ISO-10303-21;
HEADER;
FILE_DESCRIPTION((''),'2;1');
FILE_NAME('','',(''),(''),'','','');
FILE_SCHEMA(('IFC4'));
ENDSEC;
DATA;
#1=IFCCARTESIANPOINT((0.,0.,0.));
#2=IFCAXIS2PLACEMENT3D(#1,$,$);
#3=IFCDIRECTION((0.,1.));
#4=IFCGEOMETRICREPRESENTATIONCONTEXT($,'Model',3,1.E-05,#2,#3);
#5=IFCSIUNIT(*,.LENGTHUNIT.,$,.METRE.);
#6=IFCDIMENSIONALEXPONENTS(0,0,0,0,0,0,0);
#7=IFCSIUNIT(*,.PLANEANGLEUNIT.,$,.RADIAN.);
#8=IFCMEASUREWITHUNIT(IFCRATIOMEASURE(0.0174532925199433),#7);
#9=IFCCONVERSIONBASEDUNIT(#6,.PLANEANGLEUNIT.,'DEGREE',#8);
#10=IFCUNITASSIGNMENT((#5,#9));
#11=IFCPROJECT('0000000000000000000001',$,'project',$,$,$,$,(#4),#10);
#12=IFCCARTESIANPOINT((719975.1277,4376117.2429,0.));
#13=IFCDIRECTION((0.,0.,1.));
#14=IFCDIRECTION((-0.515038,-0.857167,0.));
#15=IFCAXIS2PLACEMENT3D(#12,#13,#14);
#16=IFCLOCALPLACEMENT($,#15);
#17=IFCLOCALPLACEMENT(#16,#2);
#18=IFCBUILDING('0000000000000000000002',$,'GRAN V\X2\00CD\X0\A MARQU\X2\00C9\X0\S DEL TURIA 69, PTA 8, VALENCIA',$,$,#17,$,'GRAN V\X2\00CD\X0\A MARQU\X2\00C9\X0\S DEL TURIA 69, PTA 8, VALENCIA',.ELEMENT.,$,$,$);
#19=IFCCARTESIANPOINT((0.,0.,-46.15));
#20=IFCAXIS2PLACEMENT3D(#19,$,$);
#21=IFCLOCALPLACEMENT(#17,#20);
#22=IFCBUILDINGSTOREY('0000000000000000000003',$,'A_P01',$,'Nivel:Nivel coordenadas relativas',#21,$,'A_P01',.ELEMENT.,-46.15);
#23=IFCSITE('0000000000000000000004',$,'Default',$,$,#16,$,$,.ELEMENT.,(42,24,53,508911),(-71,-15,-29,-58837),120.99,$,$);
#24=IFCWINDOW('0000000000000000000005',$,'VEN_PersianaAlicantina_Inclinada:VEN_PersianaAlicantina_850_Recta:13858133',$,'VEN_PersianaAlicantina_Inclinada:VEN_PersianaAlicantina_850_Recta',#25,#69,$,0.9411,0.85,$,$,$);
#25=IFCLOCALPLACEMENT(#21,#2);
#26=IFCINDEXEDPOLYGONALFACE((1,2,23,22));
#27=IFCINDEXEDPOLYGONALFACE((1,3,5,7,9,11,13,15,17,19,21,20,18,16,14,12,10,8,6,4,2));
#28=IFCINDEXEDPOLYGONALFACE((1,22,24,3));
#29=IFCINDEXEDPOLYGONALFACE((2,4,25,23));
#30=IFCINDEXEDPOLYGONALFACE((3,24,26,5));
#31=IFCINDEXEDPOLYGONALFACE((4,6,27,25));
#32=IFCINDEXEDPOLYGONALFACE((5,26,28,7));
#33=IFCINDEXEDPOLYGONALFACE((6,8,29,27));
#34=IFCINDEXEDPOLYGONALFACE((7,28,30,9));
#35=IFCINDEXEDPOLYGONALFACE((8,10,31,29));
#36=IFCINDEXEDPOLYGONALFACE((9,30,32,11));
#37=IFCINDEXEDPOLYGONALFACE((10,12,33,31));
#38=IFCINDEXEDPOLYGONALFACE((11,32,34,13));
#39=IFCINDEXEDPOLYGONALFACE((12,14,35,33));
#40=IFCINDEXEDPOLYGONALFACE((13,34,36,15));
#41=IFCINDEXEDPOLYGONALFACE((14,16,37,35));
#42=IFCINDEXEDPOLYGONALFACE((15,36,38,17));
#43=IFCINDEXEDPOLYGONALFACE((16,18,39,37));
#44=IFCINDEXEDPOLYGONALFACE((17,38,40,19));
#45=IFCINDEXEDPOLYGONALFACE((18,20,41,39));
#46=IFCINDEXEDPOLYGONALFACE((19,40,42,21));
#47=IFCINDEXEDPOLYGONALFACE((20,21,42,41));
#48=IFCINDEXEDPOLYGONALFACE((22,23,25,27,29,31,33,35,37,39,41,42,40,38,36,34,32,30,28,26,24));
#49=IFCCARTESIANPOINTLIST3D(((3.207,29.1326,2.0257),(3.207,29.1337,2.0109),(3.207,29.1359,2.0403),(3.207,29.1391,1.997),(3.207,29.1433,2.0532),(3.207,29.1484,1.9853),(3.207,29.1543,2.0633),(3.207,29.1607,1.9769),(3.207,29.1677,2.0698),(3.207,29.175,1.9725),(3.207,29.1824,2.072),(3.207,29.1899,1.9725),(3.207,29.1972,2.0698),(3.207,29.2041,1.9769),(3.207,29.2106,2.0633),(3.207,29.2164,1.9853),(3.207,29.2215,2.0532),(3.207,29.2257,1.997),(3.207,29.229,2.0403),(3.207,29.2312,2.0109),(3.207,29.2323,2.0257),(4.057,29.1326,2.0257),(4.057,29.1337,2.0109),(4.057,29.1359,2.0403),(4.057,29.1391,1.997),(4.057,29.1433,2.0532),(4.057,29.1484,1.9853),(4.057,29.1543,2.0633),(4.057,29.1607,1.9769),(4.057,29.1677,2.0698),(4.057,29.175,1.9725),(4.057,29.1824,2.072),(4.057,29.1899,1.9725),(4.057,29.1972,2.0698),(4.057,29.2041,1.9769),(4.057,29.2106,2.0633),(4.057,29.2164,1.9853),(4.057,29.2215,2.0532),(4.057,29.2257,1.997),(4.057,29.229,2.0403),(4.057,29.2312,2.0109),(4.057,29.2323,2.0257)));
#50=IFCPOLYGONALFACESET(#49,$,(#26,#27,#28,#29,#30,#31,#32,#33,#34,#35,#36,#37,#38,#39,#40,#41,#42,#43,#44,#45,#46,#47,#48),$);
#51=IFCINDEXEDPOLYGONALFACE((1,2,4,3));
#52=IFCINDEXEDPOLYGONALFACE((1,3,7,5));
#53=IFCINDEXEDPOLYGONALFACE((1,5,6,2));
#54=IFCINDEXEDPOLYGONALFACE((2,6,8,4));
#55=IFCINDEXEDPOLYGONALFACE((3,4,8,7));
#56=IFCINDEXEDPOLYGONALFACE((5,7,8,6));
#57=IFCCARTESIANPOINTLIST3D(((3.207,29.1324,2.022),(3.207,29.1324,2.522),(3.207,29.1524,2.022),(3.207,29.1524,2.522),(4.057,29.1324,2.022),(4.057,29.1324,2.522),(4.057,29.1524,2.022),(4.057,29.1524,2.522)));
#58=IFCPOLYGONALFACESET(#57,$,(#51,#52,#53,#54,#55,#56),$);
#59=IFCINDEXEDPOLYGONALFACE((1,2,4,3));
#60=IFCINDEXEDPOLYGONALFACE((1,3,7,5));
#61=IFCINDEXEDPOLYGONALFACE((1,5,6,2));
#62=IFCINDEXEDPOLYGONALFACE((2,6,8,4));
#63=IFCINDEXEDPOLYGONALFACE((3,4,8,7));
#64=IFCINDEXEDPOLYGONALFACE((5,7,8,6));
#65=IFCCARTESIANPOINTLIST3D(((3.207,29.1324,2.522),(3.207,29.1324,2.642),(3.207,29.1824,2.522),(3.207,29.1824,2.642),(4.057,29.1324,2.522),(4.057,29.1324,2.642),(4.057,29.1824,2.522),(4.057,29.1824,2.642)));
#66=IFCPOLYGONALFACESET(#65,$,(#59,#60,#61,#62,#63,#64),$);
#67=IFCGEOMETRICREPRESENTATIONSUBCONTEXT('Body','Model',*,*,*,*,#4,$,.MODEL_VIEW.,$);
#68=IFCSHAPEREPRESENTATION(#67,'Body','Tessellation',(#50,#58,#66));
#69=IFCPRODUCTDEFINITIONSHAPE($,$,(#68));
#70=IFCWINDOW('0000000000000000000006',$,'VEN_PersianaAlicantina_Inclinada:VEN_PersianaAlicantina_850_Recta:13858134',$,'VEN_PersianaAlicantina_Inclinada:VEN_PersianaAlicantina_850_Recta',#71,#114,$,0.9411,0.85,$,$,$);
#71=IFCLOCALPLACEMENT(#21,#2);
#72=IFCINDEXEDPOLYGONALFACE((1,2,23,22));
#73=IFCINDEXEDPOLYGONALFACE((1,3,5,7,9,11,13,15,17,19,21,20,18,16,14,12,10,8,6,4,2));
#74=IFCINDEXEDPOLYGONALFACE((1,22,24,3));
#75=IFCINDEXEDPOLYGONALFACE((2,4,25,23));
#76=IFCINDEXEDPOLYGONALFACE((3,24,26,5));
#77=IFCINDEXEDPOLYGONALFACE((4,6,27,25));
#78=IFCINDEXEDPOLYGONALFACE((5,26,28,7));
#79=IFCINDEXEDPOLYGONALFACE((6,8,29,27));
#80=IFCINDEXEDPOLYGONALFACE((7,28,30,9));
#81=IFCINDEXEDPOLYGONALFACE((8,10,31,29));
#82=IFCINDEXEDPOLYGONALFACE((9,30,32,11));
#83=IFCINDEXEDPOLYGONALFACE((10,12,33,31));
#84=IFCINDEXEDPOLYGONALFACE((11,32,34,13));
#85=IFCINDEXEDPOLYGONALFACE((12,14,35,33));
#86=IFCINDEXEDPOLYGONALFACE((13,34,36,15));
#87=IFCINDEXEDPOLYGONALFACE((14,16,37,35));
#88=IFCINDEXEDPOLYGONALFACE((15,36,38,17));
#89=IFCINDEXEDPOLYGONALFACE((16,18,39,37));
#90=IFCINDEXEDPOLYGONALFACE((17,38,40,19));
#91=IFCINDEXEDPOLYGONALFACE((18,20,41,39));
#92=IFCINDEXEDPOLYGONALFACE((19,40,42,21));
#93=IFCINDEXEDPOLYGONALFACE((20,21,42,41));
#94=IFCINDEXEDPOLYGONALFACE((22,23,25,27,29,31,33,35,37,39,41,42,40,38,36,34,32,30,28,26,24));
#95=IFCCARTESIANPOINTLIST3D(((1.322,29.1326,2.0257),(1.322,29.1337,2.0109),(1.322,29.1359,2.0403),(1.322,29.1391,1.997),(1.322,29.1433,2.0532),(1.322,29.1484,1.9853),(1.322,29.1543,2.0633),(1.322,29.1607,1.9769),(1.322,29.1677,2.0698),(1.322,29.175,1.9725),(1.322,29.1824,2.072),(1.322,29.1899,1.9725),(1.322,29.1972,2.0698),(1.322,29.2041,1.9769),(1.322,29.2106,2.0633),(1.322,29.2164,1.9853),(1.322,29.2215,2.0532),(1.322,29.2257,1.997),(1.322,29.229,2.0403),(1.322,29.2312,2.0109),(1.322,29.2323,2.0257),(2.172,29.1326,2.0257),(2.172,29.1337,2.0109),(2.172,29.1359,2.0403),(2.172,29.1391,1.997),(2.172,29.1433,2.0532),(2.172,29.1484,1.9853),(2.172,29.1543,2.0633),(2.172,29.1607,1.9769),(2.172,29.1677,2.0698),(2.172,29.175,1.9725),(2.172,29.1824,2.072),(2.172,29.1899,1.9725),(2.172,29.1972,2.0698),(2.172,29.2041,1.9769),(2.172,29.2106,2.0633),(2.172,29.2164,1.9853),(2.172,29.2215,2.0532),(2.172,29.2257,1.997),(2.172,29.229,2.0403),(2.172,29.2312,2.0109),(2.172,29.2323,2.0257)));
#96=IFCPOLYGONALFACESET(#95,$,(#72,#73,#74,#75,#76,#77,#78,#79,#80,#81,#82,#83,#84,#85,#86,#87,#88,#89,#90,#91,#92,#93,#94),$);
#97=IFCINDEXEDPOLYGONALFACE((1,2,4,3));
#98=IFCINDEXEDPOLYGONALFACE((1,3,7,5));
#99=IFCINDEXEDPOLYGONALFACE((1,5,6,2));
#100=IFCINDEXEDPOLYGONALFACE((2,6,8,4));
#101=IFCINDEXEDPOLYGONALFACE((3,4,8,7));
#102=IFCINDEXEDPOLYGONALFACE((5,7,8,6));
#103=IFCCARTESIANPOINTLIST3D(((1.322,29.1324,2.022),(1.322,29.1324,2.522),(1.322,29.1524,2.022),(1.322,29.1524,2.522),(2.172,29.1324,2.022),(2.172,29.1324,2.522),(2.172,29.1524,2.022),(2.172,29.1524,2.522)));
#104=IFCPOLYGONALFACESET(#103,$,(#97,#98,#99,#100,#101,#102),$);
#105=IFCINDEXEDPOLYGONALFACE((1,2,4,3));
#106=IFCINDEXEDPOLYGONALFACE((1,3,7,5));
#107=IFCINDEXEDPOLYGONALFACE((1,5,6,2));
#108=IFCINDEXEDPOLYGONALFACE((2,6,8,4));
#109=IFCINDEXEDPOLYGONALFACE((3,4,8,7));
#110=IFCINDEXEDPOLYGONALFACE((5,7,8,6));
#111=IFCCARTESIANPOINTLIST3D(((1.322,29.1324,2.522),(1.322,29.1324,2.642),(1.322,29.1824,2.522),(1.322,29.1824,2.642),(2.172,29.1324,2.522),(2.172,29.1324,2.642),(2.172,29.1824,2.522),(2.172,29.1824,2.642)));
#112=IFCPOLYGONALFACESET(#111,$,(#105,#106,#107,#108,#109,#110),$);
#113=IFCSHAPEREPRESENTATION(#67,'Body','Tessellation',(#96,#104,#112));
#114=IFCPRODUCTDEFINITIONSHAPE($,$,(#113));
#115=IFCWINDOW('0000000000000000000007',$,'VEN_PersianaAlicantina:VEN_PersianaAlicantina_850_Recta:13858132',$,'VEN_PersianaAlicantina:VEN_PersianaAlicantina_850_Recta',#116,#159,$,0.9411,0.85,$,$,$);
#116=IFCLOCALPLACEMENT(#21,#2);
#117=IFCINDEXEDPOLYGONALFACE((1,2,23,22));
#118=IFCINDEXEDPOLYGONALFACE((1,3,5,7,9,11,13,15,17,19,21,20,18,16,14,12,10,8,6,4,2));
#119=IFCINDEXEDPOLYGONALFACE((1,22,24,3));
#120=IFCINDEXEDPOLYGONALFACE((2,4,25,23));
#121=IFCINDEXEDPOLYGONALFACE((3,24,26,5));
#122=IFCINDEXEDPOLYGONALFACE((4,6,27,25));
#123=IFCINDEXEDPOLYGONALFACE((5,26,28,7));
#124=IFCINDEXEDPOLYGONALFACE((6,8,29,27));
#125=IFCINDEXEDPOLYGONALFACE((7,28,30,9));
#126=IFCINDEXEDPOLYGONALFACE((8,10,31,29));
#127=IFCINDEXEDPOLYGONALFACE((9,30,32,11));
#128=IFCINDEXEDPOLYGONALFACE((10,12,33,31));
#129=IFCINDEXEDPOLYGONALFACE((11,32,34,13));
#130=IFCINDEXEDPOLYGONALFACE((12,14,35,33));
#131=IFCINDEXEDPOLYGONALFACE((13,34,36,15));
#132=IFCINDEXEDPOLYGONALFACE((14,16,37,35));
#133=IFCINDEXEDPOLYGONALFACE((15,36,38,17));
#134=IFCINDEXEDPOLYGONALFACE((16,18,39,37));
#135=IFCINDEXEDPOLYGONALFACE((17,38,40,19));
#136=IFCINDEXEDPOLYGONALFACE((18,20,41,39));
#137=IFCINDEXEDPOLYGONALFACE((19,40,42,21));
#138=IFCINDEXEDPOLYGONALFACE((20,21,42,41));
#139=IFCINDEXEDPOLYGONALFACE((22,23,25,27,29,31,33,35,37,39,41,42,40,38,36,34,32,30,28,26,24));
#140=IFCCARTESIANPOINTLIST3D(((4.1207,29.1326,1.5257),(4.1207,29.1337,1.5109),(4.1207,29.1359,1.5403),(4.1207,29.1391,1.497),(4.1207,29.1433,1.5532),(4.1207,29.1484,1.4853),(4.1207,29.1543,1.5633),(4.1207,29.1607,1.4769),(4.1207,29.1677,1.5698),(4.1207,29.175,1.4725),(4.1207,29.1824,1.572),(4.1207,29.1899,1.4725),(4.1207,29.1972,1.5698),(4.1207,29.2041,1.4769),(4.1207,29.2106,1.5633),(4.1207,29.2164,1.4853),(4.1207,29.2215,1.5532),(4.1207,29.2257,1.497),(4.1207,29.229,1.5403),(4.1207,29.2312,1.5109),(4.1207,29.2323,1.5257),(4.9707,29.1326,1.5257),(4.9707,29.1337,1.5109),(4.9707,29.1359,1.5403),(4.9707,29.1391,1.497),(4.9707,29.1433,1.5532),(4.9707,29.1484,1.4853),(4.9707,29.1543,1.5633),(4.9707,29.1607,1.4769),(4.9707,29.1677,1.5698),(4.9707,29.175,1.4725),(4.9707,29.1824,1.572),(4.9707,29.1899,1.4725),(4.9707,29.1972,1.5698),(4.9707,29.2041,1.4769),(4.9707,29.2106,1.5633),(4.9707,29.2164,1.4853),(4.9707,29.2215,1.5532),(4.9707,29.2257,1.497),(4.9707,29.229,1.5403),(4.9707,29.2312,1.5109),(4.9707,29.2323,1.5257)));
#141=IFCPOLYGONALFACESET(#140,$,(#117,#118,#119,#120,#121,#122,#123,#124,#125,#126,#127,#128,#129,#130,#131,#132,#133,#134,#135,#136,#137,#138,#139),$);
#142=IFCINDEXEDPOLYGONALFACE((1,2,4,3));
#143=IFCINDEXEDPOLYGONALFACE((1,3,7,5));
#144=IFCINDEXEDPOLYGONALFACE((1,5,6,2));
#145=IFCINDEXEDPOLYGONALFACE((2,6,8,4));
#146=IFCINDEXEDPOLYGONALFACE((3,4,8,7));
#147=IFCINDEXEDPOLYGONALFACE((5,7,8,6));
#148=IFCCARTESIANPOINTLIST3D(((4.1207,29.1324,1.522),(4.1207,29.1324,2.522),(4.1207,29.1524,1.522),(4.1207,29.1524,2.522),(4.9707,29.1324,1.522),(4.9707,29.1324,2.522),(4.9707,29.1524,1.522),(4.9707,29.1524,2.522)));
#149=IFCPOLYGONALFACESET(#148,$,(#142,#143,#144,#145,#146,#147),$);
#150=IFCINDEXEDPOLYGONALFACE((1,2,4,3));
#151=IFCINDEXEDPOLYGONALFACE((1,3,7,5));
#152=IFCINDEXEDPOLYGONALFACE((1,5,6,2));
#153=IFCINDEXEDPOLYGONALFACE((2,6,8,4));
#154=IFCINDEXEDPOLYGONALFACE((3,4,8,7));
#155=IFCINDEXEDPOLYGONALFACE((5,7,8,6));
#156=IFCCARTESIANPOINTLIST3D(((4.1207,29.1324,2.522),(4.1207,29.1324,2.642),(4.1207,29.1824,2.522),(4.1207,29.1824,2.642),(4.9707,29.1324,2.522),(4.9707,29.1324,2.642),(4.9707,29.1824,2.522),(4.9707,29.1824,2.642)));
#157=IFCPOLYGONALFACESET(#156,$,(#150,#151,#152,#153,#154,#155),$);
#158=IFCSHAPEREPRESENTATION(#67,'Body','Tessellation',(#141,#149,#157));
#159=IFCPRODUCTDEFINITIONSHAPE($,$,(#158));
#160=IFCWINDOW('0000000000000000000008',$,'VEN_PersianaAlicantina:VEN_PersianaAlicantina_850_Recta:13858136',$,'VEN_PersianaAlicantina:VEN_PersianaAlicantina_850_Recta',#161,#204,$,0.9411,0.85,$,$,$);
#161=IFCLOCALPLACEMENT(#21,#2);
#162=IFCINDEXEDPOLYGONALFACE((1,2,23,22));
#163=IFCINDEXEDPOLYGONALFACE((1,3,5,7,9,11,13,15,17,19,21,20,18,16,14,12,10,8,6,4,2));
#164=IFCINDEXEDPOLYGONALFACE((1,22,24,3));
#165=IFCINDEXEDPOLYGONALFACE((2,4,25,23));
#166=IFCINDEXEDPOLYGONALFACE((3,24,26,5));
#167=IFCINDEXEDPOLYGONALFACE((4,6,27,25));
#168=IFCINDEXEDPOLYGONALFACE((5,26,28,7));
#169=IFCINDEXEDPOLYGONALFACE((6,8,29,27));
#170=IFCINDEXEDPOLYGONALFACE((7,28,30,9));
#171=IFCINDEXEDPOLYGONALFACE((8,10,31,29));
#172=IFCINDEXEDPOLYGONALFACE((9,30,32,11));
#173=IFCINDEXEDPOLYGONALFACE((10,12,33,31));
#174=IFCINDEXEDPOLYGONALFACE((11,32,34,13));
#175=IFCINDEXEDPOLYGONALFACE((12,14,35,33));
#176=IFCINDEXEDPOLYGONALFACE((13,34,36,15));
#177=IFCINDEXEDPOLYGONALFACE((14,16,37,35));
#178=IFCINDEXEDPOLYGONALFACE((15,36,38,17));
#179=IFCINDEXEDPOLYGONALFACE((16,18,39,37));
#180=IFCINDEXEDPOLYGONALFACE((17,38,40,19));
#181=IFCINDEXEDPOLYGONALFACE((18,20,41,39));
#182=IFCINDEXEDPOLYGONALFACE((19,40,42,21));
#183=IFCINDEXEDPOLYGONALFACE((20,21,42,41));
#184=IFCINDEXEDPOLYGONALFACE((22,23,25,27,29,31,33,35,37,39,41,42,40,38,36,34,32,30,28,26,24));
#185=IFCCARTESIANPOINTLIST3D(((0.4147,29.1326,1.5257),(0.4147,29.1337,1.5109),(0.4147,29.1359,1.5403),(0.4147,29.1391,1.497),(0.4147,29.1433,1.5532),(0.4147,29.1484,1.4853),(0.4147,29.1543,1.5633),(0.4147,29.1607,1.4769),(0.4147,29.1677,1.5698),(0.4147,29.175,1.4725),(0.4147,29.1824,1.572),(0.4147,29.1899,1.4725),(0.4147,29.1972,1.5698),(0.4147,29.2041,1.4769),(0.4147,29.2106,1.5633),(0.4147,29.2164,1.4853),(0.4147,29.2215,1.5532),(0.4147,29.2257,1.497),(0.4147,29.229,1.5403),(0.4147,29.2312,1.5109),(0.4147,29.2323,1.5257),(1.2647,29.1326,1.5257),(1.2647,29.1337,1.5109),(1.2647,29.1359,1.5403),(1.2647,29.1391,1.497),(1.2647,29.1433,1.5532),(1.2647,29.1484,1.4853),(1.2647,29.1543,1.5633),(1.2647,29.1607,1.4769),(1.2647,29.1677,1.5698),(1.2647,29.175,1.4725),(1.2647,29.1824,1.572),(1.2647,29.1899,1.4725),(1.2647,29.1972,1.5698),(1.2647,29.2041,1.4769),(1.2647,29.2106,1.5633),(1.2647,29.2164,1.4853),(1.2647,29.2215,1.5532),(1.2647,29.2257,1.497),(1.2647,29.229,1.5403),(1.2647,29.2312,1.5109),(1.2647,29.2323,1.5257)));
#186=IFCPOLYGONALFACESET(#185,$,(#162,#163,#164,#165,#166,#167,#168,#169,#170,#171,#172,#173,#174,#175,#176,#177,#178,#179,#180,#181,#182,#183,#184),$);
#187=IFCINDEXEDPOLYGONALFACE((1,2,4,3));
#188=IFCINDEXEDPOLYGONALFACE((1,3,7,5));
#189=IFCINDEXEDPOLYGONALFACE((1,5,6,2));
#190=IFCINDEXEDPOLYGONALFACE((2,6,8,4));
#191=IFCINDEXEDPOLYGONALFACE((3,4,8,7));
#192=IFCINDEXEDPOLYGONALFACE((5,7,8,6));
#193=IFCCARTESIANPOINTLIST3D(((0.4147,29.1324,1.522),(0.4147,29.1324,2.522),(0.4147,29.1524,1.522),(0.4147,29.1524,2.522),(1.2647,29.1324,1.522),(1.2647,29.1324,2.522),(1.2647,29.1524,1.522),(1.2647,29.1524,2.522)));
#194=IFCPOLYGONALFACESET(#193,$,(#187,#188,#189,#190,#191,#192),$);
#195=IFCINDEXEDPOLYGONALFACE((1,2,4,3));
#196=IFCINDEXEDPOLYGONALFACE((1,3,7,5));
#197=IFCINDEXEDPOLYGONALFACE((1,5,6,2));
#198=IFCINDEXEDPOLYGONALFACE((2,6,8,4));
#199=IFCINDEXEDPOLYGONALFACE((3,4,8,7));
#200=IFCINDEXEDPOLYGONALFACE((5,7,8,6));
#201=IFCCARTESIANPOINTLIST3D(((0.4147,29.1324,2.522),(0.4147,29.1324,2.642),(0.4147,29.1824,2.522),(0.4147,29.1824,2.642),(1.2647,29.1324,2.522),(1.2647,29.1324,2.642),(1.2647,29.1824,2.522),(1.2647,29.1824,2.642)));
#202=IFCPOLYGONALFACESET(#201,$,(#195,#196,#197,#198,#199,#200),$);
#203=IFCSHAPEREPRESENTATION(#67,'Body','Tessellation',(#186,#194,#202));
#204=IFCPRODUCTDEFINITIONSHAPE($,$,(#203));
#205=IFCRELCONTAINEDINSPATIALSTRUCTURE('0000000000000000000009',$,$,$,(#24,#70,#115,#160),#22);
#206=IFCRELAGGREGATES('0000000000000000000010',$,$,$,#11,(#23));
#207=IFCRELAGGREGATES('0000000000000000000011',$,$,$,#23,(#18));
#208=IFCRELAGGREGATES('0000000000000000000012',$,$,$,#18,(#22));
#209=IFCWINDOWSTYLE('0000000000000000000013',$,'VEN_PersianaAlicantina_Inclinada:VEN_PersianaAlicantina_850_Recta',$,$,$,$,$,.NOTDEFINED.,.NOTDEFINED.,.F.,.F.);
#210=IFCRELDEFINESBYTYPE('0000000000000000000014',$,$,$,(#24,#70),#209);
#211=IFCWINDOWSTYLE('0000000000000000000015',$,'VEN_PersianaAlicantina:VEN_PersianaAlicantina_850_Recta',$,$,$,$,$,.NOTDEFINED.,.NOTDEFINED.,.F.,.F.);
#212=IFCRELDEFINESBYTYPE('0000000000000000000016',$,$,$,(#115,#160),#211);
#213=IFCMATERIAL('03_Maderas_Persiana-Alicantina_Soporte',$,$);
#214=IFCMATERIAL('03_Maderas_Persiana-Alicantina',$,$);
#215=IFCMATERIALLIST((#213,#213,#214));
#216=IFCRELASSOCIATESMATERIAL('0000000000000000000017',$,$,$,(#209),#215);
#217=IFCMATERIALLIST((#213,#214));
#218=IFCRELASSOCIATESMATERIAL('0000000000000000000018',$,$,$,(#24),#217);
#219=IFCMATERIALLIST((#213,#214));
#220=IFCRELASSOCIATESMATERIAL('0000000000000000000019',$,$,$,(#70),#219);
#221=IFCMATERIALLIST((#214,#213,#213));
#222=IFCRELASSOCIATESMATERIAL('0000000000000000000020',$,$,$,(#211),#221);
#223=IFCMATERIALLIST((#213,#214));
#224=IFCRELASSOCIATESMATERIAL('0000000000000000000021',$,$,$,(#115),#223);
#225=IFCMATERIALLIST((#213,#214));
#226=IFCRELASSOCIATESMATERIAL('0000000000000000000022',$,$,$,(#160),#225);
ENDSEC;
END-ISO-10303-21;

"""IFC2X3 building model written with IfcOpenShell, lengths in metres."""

from ifc_helpers import new_model, entity, si_unit, converted_unit, direction, frame, frame_2d, origin, origin_2d_with_axis, place, context, subcontext, project, spatial, rectangle, circle, extrude, source, transform, mapped, material, material_list, type_object, type_shapes, element, save


model = new_model("IFC2X3")

# Units and contexts
model_context = context("Model", 3, precision=1e-05, world=origin(), true_north=direction((0.0, 1.0)))
body_context = subcontext(model_context, "Body", "Model", "MODEL_VIEW")
ifc_project = project(units=[si_unit("LENGTHUNIT", "METRE"), converted_unit("PLANEANGLEUNIT", "DEGREE", entity("IfcRatioMeasure", 0.0174532925199433), si_unit("PLANEANGLEUNIT", "RADIAN"), dimensions=[0, 0, 0, 0, 0, 0, 0])], contexts=[model_context])

# Site, building, storey
site_placement = place(None, frame((719975.1277, 4376117.2429, 0.0), z_axis=(0.0, 0.0, 1.0), x_axis=(-0.515038, -0.857167, 0.0)))
site = spatial("IfcSite", under=ifc_project, at=site_placement, Name="Default", CompositionType="ELEMENT", RefLatitude=(42, 24, 53, 508911), RefLongitude=(-71, -15, -29, -58837), RefElevation=120.99)
building_placement = place(site_placement, origin())
building = spatial("IfcBuilding", under=site, at=building_placement, Name="GRAN VÍA MARQUÉS DEL TURIA 69, PTA 8, VALENCIA", LongName="GRAN VÍA MARQUÉS DEL TURIA 69, PTA 8, VALENCIA", CompositionType="ELEMENT")
storey_placement = place(building_placement, frame((0.0, 0.0, -46.15)))
storey = spatial("IfcBuildingStorey", under=building, at=storey_placement, Name="A_P01", ObjectType="Nivel:Nivel coordenadas relativas", LongName="A_P01", CompositionType="ELEMENT", Elevation=-46.15)

# Windows
ifc_material_1 = material(Name="03_Maderas_Persiana-Alicantina_Soporte")
ifc_material_2 = material(Name="03_Maderas_Persiana-Alicantina")
ifc_material_list_1 = material_list([ifc_material_1, ifc_material_2])
ifc_material_list_2 = material_list([ifc_material_1, ifc_material_1, ifc_material_2])
window_style_1 = type_object("IfcWindowStyle", Name="VEN_PersianaAlicantina_Inclinada:VEN_PersianaAlicantina_850_Recta", ConstructionType="NOTDEFINED", OperationType="NOTDEFINED", ParameterTakesPrecedence=False, Sizeable=False, material=ifc_material_list_2)
shared_shape_1 = source(origin(), body_context, "Body", "SweptSolid", [
    extrude(circle(Radius=0.05, at=frame_2d((0.0, 0.0), x_axis=(1.0, 0.0))), frame((-0.425, -0.0392, 0.05), z_axis=(1.0, 0.0, 0.0), x_axis=(0.0, 1.0, 0.0)), (0.0, 0.0, 1.0), 0.85),
    extrude(rectangle(XDim=0.85, YDim=0.5, at=origin_2d_with_axis()), frame((0.0, 0.2108, 0.0), z_axis=(0.0, 0.0, 1.0), x_axis=(-1.0, 0.0, 0.0)), (0.0, 0.0, 1.0), 0.02),
    extrude(rectangle(XDim=0.85, YDim=0.12, at=frame_2d((0.0, 0.0), x_axis=(1.0, 0.0))), frame((0.0, 0.5208, 0.0), z_axis=(0.0, 0.0, 1.0), x_axis=(-1.0, 0.0, 0.0)), (0.0, 0.0, 1.0), 0.05),
])
type_shapes(window_style_1, [shared_shape_1])
window_1_placement = place(storey_placement, frame((3.632, 29.1324, 2.0612), z_axis=(0.0, 1.0, 0.0), x_axis=(-1.0, 0.0, 0.0)))
element("IfcWindow", 1, at=window_1_placement, inside=storey, type_object=window_style_1, material=ifc_material_list_1, Name="VEN_PersianaAlicantina_Inclinada:VEN_PersianaAlicantina_850_Recta:13858133", ObjectType="VEN_PersianaAlicantina_Inclinada:VEN_PersianaAlicantina_850_Recta", OverallHeight=0.9411, OverallWidth=0.85, context=body_context, shape_type="MappedRepresentation", body=[
    mapped(shared_shape_1, transform((0.0, 0.0, 0.0), scale=1.0)),
])
ifc_material_list_3 = material_list([ifc_material_1, ifc_material_2])
window_2_placement = place(storey_placement, frame((1.747, 29.1324, 2.0612), z_axis=(0.0, 1.0, 0.0), x_axis=(-1.0, 0.0, 0.0)))
element("IfcWindow", 2, at=window_2_placement, inside=storey, type_object=window_style_1, material=ifc_material_list_3, Name="VEN_PersianaAlicantina_Inclinada:VEN_PersianaAlicantina_850_Recta:13858134", ObjectType="VEN_PersianaAlicantina_Inclinada:VEN_PersianaAlicantina_850_Recta", OverallHeight=0.9411, OverallWidth=0.85, context=body_context, shape_type="MappedRepresentation", body=[
    mapped(shared_shape_1, transform((0.0, 0.0, 0.0), scale=1.0)),
])
ifc_material_list_4 = material_list([ifc_material_1, ifc_material_2])
ifc_material_list_5 = material_list([ifc_material_2, ifc_material_1, ifc_material_1])
window_style_2 = type_object("IfcWindowStyle", Name="VEN_PersianaAlicantina:VEN_PersianaAlicantina_850_Recta", ConstructionType="NOTDEFINED", OperationType="NOTDEFINED", ParameterTakesPrecedence=False, Sizeable=False, material=ifc_material_list_5)
shared_shape_2 = source(origin(), body_context, "Body", "SweptSolid", [
    extrude(circle(Radius=0.05, at=frame_2d((0.0, 0.0), x_axis=(1.0, 0.0))), frame((-0.425, -0.5392, 0.05), z_axis=(1.0, 0.0, 0.0), x_axis=(0.0, 1.0, 0.0)), (0.0, 0.0, 1.0), 0.85),
    extrude(rectangle(XDim=0.85, YDim=1.0, at=frame_2d((0.0, 0.0), x_axis=(1.0, 0.0))), frame((0.0, -0.0392, 0.0), z_axis=(0.0, 0.0, 1.0), x_axis=(-1.0, 0.0, 0.0)), (0.0, 0.0, 1.0), 0.02),
    extrude(rectangle(XDim=0.85, YDim=0.12, at=frame_2d((0.0, 0.0), x_axis=(1.0, 0.0))), frame((0.0, 0.5208, 0.0), z_axis=(0.0, 0.0, 1.0), x_axis=(-1.0, 0.0, 0.0)), (0.0, 0.0, 1.0), 0.05),
])
type_shapes(window_style_2, [shared_shape_2])
window_3_placement = place(storey_placement, frame((4.5457, 29.1324, 2.0612), z_axis=(0.0, 1.0, 0.0), x_axis=(-1.0, 0.0, 0.0)))
element("IfcWindow", 3, at=window_3_placement, inside=storey, type_object=window_style_2, material=ifc_material_list_4, Name="VEN_PersianaAlicantina:VEN_PersianaAlicantina_850_Recta:13858132", ObjectType="VEN_PersianaAlicantina:VEN_PersianaAlicantina_850_Recta", OverallHeight=0.9411, OverallWidth=0.85, context=body_context, shape_type="MappedRepresentation", body=[
    mapped(shared_shape_2, transform((0.0, 0.0, 0.0), scale=1.0)),
])
ifc_material_list_6 = material_list([ifc_material_1, ifc_material_2])
window_4_placement = place(storey_placement, frame((0.8397, 29.1324, 2.0612), z_axis=(0.0, 1.0, 0.0), x_axis=(-1.0, 0.0, 0.0)))
element("IfcWindow", 4, at=window_4_placement, inside=storey, type_object=window_style_2, material=ifc_material_list_6, Name="VEN_PersianaAlicantina:VEN_PersianaAlicantina_850_Recta:13858136", ObjectType="VEN_PersianaAlicantina:VEN_PersianaAlicantina_850_Recta", OverallHeight=0.9411, OverallWidth=0.85, context=body_context, shape_type="MappedRepresentation", body=[
    mapped(shared_shape_2, transform((0.0, 0.0, 0.0), scale=1.0)),
])

save(model, "model.ifc")
